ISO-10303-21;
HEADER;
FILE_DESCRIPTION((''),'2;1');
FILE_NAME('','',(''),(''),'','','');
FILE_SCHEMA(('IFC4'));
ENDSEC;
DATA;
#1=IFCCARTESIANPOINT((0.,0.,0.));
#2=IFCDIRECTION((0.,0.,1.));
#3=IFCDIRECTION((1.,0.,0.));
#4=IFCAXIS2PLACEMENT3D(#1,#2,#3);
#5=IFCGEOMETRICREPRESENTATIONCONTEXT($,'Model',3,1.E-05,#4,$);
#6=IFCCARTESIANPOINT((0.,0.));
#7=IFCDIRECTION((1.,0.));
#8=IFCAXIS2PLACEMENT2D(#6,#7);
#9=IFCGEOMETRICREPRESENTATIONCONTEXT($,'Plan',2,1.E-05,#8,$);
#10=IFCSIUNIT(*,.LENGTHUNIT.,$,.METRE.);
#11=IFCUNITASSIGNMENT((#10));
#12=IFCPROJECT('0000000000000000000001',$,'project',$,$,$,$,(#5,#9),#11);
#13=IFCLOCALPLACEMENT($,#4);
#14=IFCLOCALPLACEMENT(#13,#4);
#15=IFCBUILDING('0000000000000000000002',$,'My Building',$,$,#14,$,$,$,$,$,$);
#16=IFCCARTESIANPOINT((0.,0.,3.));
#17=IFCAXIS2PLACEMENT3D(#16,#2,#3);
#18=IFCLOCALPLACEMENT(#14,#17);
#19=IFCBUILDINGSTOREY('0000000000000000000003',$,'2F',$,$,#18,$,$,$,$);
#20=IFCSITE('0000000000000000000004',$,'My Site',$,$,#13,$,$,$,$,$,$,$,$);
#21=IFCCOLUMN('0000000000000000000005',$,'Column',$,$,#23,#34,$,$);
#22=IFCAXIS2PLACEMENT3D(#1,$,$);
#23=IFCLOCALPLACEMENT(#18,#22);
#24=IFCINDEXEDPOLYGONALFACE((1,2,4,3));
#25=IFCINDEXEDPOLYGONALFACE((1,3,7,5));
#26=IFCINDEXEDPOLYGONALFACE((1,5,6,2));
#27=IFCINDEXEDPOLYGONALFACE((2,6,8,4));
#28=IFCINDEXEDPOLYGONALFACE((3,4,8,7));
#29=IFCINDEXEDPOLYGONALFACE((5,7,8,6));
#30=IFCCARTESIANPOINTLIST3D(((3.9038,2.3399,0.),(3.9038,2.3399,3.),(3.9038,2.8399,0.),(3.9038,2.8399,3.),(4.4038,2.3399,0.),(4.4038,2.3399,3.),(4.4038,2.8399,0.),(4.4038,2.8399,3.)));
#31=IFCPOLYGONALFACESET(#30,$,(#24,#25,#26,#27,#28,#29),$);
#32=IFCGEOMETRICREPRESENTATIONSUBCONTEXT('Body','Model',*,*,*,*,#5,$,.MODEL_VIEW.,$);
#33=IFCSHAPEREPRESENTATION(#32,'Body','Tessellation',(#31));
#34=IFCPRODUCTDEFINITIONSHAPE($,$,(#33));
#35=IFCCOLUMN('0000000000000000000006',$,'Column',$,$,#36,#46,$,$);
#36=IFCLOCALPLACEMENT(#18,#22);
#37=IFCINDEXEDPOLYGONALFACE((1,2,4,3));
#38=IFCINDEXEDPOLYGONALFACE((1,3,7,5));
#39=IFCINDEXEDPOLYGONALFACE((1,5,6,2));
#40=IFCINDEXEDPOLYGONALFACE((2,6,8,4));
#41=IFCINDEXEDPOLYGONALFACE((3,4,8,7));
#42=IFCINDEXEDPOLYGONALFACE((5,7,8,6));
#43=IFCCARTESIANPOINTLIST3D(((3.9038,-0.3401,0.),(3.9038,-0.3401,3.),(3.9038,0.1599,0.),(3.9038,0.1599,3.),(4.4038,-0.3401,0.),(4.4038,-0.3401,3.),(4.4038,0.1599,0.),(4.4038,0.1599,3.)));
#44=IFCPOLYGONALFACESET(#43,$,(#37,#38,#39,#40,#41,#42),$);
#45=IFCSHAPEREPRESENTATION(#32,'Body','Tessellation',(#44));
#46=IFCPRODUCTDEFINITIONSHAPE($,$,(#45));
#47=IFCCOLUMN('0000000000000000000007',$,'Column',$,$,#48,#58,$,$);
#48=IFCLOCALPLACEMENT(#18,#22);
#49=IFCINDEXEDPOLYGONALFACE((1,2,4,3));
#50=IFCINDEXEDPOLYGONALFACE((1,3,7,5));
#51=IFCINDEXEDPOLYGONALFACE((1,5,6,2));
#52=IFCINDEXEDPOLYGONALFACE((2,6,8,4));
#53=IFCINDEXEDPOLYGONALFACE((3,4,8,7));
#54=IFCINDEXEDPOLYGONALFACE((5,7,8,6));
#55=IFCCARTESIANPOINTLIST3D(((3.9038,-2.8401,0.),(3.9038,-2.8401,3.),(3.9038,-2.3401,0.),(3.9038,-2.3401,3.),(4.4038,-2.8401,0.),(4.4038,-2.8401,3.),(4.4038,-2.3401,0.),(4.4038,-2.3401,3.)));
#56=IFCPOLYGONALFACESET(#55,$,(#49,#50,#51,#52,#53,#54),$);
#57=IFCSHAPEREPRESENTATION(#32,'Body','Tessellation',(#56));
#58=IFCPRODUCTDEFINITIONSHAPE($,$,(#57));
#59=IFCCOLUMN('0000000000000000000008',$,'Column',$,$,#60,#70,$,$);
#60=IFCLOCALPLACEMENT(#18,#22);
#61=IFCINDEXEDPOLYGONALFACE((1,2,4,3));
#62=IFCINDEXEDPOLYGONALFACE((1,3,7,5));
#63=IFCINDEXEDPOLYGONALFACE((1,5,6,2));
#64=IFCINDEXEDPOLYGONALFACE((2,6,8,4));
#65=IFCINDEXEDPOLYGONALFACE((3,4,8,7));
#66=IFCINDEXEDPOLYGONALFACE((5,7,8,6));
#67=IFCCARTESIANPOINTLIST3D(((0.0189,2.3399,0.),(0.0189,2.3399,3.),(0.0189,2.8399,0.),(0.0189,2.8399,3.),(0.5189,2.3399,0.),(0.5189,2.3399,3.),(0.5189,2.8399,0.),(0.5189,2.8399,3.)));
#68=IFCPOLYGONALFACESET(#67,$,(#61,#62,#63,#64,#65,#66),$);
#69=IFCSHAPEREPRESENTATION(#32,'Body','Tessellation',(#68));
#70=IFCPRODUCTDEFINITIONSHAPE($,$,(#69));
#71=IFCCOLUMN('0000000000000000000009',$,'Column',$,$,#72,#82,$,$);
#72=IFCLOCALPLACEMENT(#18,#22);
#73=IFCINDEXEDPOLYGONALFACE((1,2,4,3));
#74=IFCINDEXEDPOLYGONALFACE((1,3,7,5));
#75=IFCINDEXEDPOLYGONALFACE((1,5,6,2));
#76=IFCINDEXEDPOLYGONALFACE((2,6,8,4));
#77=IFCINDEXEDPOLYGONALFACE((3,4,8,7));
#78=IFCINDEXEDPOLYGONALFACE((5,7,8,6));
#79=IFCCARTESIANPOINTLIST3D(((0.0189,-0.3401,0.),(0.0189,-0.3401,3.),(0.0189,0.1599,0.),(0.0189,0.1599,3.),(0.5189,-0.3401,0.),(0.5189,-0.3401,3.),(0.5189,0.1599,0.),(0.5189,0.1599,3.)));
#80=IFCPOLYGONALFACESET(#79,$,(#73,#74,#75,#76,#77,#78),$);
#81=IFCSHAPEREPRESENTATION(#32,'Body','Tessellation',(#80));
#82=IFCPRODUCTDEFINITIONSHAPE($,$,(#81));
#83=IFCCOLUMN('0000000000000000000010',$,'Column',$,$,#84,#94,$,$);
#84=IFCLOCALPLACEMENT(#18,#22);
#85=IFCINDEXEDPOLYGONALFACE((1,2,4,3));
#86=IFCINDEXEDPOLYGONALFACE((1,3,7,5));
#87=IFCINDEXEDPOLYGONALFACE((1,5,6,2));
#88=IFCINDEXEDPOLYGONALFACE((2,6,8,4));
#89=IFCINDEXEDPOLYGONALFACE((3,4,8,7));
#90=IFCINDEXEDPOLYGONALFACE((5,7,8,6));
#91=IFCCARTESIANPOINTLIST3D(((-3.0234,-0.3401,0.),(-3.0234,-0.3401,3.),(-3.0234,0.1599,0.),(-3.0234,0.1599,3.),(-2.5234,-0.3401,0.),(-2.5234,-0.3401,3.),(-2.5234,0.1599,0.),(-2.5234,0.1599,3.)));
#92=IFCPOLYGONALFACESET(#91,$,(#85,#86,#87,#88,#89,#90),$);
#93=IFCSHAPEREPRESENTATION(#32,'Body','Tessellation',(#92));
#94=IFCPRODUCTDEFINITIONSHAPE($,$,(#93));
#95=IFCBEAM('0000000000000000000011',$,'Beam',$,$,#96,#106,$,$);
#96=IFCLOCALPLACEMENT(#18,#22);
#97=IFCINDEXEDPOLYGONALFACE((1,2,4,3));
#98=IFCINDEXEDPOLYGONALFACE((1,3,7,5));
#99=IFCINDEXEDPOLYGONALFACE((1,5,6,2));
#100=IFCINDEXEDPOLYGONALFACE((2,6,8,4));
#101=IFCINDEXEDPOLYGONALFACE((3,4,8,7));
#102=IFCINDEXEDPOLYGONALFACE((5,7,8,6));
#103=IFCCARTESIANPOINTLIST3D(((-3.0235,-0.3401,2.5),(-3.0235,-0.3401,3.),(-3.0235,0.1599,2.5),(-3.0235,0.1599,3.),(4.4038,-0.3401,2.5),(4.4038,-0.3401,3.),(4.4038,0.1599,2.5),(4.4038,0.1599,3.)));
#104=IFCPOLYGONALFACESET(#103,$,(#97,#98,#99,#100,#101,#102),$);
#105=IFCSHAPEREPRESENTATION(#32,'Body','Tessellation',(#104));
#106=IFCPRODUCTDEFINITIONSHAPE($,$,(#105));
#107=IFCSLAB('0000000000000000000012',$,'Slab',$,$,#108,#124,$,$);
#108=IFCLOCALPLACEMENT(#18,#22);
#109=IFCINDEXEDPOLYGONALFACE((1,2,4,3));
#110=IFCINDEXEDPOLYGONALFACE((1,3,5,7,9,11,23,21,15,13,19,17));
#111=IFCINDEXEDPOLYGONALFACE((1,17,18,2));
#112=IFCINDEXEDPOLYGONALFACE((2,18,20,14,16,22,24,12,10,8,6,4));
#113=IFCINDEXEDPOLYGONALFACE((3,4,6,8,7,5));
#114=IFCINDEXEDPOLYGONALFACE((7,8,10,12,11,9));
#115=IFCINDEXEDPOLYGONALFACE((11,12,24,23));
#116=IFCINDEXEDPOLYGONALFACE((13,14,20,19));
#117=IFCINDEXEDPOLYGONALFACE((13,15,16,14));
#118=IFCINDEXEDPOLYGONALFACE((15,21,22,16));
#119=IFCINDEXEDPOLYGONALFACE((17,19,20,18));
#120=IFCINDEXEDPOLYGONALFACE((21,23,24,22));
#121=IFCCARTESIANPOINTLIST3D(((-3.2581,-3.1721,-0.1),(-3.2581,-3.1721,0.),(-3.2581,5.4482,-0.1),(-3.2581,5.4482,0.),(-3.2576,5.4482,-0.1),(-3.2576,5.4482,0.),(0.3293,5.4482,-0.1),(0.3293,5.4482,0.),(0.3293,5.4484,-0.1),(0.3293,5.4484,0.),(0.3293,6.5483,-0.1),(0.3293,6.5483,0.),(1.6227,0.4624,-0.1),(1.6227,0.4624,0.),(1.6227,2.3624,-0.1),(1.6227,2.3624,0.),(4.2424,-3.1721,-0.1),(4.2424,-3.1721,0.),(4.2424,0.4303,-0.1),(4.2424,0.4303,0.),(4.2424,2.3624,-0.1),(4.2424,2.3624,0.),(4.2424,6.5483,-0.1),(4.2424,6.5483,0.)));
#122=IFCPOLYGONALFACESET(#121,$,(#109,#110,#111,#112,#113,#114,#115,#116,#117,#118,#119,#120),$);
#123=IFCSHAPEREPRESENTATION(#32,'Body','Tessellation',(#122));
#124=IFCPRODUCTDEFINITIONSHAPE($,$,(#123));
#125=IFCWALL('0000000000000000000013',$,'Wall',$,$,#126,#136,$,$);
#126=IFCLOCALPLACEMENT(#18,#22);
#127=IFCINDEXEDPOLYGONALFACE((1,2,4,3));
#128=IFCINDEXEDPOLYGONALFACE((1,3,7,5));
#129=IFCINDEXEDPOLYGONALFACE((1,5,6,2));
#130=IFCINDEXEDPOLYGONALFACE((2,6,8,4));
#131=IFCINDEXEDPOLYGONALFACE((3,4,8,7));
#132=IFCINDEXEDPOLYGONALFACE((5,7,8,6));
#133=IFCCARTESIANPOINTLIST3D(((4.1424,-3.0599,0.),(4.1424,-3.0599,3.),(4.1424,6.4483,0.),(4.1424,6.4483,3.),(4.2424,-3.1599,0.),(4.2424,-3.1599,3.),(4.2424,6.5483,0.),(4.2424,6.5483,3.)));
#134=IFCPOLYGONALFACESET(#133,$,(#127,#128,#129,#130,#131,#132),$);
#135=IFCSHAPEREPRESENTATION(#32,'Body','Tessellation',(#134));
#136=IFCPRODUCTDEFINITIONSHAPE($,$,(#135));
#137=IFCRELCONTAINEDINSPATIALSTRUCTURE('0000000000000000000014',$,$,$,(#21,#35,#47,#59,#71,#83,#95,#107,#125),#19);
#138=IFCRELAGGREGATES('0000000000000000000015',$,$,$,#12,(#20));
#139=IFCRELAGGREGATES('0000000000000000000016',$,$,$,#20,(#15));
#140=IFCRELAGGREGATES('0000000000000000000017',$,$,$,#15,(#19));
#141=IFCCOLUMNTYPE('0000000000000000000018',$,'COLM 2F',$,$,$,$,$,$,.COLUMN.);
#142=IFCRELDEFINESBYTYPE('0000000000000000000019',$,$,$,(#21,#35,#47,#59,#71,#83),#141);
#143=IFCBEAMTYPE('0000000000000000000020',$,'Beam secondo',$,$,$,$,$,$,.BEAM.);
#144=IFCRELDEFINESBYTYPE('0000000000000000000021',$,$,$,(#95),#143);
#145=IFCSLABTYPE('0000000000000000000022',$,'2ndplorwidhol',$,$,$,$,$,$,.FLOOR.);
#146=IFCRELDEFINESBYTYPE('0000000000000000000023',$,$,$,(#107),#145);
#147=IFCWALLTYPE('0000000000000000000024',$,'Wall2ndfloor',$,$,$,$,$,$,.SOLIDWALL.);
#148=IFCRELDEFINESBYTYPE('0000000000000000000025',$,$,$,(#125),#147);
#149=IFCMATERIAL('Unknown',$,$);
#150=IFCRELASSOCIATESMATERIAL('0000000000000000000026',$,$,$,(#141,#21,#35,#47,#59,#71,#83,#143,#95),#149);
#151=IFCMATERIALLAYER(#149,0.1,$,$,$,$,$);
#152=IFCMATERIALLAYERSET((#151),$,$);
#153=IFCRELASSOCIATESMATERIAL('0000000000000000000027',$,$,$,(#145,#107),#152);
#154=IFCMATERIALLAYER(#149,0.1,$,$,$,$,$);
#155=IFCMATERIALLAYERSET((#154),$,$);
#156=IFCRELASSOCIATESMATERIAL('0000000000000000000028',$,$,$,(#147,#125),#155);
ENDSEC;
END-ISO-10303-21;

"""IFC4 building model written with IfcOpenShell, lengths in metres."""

from ifc_helpers import new_model, si_unit, frame, origin_with_axes, origin_2d_with_axis, place, context, subcontext, project, spatial, line, indexed_curve, rectangle, outline, extrude, material, layer, layer_set, layer_usage, material_profile, profile_set, profile_usage, type_object, element, save


model = new_model("IFC4")

# Units and contexts
model_context = context("Model", 3, precision=1e-05, world=origin_with_axes())
plan_context = context("Plan", 2, precision=1e-05, world=origin_2d_with_axis())
body_context_1 = subcontext(model_context, "Body", "Model", "MODEL_VIEW")
ifc_project = project(units=[si_unit("LENGTHUNIT", "METRE")], contexts=[model_context, plan_context])

# Site, building, storey
site_placement = place(None, origin_with_axes())
site = spatial("IfcSite", under=ifc_project, at=site_placement, Name="My Site")
building_placement = place(site_placement, origin_with_axes())
building = spatial("IfcBuilding", under=site, at=building_placement, Name="My Building")
storey_placement = place(building_placement, frame((0.0, 0.0, 3.0), z_axis=(0.0, 0.0, 1.0), x_axis=(1.0, 0.0, 0.0)))
storey = spatial("IfcBuildingStorey", under=building, at=storey_placement, Name="2F")

# Columns
ifc_material = material(Name="Unknown")
ifc_material_profile_1 = material_profile(ifc_material, rectangle(XDim=0.5, YDim=0.5))
ifc_profile_set_1 = profile_set([ifc_material_profile_1])
ifc_profile_usage_1 = profile_usage(ifc_profile_set_1, cardinal=5)
column_type = type_object("IfcColumnType", Name="COLM 2F", PredefinedType="COLUMN", material=ifc_profile_set_1)
column_1_placement = place(storey_placement, frame((4.1538, 2.5899, 0.0), z_axis=(0.0, 0.0, 1.0), x_axis=(1.0, 0.0, 0.0)))
element("IfcColumn", 1, at=column_1_placement, inside=storey, type_object=column_type, material=ifc_profile_usage_1, Name="Column", context=body_context_1, shape_type="SweptSolid", body=[
    extrude(rectangle(XDim=0.5, YDim=0.5), origin_with_axes(), (0.0, 0.0, 1.0), 3.0),
])
ifc_profile_usage_2 = profile_usage(ifc_profile_set_1, cardinal=5)
column_2_placement = place(storey_placement, frame((4.1538, -0.0901, 0.0), z_axis=(0.0, 0.0, 1.0), x_axis=(1.0, 0.0, 0.0)))
element("IfcColumn", 2, at=column_2_placement, inside=storey, type_object=column_type, material=ifc_profile_usage_2, Name="Column", context=body_context_1, shape_type="SweptSolid", body=[
    extrude(rectangle(XDim=0.5, YDim=0.5), origin_with_axes(), (0.0, 0.0, 1.0), 3.0),
])
ifc_profile_usage_3 = profile_usage(ifc_profile_set_1, cardinal=5)
column_3_placement = place(storey_placement, frame((4.1538, -2.5901, 0.0), z_axis=(0.0, 0.0, 1.0), x_axis=(1.0, 0.0, 0.0)))
element("IfcColumn", 3, at=column_3_placement, inside=storey, type_object=column_type, material=ifc_profile_usage_3, Name="Column", context=body_context_1, shape_type="SweptSolid", body=[
    extrude(rectangle(XDim=0.5, YDim=0.5), origin_with_axes(), (0.0, 0.0, 1.0), 3.0),
])
ifc_profile_usage_4 = profile_usage(ifc_profile_set_1, cardinal=5)
column_4_placement = place(storey_placement, frame((0.2689, 2.5899, 0.0), z_axis=(0.0, 0.0, 1.0), x_axis=(1.0, 0.0, 0.0)))
element("IfcColumn", 4, at=column_4_placement, inside=storey, type_object=column_type, material=ifc_profile_usage_4, Name="Column", context=body_context_1, shape_type="SweptSolid", body=[
    extrude(rectangle(XDim=0.5, YDim=0.5), origin_with_axes(), (0.0, 0.0, 1.0), 3.0),
])
ifc_profile_usage_5 = profile_usage(ifc_profile_set_1, cardinal=5)
column_5_placement = place(storey_placement, frame((0.2689, -0.0901, 0.0), z_axis=(0.0, 0.0, 1.0), x_axis=(1.0, 0.0, 0.0)))
element("IfcColumn", 5, at=column_5_placement, inside=storey, type_object=column_type, material=ifc_profile_usage_5, Name="Column", context=body_context_1, shape_type="SweptSolid", body=[
    extrude(rectangle(XDim=0.5, YDim=0.5), origin_with_axes(), (0.0, 0.0, 1.0), 3.0),
])
ifc_profile_usage_6 = profile_usage(ifc_profile_set_1, cardinal=5)
column_6_placement = place(storey_placement, frame((-2.7734, -0.0901, 0.0), z_axis=(0.0, 0.0, 1.0), x_axis=(1.0, 0.0, 0.0)))
element("IfcColumn", 6, at=column_6_placement, inside=storey, type_object=column_type, material=ifc_profile_usage_6, Name="Column", context=body_context_1, shape_type="SweptSolid", body=[
    extrude(rectangle(XDim=0.5, YDim=0.5), origin_with_axes(), (0.0, 0.0, 1.0), 3.0),
])

# Beam
ifc_material_profile_2 = material_profile(ifc_material, rectangle(XDim=0.5, YDim=0.5))
ifc_profile_set_2 = profile_set([ifc_material_profile_2])
ifc_profile_usage_7 = profile_usage(ifc_profile_set_2, cardinal=7)
beam_type = type_object("IfcBeamType", Name="Beam secondo", PredefinedType="BEAM", material=ifc_profile_set_2)
beam_placement = place(storey_placement, frame((-3.0235, 0.1599, 3.0), z_axis=(1.0, 0.0, 0.0), x_axis=(0.0, 1.0, 0.0)))
element("IfcBeam", 7, at=beam_placement, inside=storey, type_object=beam_type, material=ifc_profile_usage_7, Name="Beam", context=body_context_1, shape_type="SweptSolid", body=[
    extrude(rectangle(XDim=0.5, YDim=0.5), frame((-0.25, -0.25, 0.0), z_axis=(0.0, 0.0, 1.0), x_axis=(1.0, 0.0, 0.0)), (0.0, 0.0, 1.0), 7.4273),
])

# Slab
ifc_layer_1 = layer(ifc_material, 0.1)
ifc_layer_set_1 = layer_set([ifc_layer_1])
ifc_layer_usage_1 = layer_usage(ifc_layer_set_1, "AXIS3", "POSITIVE", -0.1)
slab_type = type_object("IfcSlabType", Name="2ndplorwidhol", PredefinedType="FLOOR", material=ifc_layer_set_1)
slab_placement = place(storey_placement, frame((1.6227, 0.4624, 0.0), z_axis=(0.0, 0.0, 1.0), x_axis=(1.0, 0.0, 0.0)))
element("IfcSlab", 8, at=slab_placement, inside=storey, type_object=slab_type, material=ifc_layer_usage_1, Name="Slab", context=body_context_1, shape_type="SweptSolid", body=[
    extrude(outline(indexed_curve([(0.0, 0.0), (0.0, 1.9), (2.6196, 1.9), (2.6196, 6.0859), (-1.2935, 6.0859), (-1.2935, 4.9859), (-1.2935, 4.9858), (-4.8804, 4.9858), (-4.8808, 4.9858), (-4.8808, -3.6345), (2.6196, -3.6345), (2.6196, -0.0321), (0.0, 0.0)])), frame((0.0, 0.0, -0.1), z_axis=(0.0, 0.0, 1.0), x_axis=(1.0, 0.0, 0.0)), (0.0, 0.0, 1.0), 0.1),
])

# Wall
ifc_layer_2 = layer(ifc_material, 0.1)
ifc_layer_set_2 = layer_set([ifc_layer_2])
ifc_layer_usage_2 = layer_usage(ifc_layer_set_2, "AXIS2", "POSITIVE", 0.0)
wall_type = type_object("IfcWallType", Name="Wall2ndfloor", PredefinedType="SOLIDWALL", material=ifc_layer_set_2)
wall_1_placement = place(storey_placement, frame((4.2424, -3.1599, 0.0), z_axis=(0.0, 0.0, 1.0), x_axis=(0.0, 1.0, 0.0)))
element("IfcWall", 9, at=wall_1_placement, inside=storey, type_object=wall_type, material=ifc_layer_usage_2, Name="Wall", context=body_context_1, shape_type="SweptSolid", body=[
    extrude(outline(indexed_curve([(0.0, 0.0), (0.1, 0.1), (9.6082, 0.1), (9.7082, 0.0)], segments=[line(1, 2, 3, 4, 1)])), origin_with_axes(), (0.0, 0.0, 1.0), 3.0),
])

save(model, "model.ifc")
